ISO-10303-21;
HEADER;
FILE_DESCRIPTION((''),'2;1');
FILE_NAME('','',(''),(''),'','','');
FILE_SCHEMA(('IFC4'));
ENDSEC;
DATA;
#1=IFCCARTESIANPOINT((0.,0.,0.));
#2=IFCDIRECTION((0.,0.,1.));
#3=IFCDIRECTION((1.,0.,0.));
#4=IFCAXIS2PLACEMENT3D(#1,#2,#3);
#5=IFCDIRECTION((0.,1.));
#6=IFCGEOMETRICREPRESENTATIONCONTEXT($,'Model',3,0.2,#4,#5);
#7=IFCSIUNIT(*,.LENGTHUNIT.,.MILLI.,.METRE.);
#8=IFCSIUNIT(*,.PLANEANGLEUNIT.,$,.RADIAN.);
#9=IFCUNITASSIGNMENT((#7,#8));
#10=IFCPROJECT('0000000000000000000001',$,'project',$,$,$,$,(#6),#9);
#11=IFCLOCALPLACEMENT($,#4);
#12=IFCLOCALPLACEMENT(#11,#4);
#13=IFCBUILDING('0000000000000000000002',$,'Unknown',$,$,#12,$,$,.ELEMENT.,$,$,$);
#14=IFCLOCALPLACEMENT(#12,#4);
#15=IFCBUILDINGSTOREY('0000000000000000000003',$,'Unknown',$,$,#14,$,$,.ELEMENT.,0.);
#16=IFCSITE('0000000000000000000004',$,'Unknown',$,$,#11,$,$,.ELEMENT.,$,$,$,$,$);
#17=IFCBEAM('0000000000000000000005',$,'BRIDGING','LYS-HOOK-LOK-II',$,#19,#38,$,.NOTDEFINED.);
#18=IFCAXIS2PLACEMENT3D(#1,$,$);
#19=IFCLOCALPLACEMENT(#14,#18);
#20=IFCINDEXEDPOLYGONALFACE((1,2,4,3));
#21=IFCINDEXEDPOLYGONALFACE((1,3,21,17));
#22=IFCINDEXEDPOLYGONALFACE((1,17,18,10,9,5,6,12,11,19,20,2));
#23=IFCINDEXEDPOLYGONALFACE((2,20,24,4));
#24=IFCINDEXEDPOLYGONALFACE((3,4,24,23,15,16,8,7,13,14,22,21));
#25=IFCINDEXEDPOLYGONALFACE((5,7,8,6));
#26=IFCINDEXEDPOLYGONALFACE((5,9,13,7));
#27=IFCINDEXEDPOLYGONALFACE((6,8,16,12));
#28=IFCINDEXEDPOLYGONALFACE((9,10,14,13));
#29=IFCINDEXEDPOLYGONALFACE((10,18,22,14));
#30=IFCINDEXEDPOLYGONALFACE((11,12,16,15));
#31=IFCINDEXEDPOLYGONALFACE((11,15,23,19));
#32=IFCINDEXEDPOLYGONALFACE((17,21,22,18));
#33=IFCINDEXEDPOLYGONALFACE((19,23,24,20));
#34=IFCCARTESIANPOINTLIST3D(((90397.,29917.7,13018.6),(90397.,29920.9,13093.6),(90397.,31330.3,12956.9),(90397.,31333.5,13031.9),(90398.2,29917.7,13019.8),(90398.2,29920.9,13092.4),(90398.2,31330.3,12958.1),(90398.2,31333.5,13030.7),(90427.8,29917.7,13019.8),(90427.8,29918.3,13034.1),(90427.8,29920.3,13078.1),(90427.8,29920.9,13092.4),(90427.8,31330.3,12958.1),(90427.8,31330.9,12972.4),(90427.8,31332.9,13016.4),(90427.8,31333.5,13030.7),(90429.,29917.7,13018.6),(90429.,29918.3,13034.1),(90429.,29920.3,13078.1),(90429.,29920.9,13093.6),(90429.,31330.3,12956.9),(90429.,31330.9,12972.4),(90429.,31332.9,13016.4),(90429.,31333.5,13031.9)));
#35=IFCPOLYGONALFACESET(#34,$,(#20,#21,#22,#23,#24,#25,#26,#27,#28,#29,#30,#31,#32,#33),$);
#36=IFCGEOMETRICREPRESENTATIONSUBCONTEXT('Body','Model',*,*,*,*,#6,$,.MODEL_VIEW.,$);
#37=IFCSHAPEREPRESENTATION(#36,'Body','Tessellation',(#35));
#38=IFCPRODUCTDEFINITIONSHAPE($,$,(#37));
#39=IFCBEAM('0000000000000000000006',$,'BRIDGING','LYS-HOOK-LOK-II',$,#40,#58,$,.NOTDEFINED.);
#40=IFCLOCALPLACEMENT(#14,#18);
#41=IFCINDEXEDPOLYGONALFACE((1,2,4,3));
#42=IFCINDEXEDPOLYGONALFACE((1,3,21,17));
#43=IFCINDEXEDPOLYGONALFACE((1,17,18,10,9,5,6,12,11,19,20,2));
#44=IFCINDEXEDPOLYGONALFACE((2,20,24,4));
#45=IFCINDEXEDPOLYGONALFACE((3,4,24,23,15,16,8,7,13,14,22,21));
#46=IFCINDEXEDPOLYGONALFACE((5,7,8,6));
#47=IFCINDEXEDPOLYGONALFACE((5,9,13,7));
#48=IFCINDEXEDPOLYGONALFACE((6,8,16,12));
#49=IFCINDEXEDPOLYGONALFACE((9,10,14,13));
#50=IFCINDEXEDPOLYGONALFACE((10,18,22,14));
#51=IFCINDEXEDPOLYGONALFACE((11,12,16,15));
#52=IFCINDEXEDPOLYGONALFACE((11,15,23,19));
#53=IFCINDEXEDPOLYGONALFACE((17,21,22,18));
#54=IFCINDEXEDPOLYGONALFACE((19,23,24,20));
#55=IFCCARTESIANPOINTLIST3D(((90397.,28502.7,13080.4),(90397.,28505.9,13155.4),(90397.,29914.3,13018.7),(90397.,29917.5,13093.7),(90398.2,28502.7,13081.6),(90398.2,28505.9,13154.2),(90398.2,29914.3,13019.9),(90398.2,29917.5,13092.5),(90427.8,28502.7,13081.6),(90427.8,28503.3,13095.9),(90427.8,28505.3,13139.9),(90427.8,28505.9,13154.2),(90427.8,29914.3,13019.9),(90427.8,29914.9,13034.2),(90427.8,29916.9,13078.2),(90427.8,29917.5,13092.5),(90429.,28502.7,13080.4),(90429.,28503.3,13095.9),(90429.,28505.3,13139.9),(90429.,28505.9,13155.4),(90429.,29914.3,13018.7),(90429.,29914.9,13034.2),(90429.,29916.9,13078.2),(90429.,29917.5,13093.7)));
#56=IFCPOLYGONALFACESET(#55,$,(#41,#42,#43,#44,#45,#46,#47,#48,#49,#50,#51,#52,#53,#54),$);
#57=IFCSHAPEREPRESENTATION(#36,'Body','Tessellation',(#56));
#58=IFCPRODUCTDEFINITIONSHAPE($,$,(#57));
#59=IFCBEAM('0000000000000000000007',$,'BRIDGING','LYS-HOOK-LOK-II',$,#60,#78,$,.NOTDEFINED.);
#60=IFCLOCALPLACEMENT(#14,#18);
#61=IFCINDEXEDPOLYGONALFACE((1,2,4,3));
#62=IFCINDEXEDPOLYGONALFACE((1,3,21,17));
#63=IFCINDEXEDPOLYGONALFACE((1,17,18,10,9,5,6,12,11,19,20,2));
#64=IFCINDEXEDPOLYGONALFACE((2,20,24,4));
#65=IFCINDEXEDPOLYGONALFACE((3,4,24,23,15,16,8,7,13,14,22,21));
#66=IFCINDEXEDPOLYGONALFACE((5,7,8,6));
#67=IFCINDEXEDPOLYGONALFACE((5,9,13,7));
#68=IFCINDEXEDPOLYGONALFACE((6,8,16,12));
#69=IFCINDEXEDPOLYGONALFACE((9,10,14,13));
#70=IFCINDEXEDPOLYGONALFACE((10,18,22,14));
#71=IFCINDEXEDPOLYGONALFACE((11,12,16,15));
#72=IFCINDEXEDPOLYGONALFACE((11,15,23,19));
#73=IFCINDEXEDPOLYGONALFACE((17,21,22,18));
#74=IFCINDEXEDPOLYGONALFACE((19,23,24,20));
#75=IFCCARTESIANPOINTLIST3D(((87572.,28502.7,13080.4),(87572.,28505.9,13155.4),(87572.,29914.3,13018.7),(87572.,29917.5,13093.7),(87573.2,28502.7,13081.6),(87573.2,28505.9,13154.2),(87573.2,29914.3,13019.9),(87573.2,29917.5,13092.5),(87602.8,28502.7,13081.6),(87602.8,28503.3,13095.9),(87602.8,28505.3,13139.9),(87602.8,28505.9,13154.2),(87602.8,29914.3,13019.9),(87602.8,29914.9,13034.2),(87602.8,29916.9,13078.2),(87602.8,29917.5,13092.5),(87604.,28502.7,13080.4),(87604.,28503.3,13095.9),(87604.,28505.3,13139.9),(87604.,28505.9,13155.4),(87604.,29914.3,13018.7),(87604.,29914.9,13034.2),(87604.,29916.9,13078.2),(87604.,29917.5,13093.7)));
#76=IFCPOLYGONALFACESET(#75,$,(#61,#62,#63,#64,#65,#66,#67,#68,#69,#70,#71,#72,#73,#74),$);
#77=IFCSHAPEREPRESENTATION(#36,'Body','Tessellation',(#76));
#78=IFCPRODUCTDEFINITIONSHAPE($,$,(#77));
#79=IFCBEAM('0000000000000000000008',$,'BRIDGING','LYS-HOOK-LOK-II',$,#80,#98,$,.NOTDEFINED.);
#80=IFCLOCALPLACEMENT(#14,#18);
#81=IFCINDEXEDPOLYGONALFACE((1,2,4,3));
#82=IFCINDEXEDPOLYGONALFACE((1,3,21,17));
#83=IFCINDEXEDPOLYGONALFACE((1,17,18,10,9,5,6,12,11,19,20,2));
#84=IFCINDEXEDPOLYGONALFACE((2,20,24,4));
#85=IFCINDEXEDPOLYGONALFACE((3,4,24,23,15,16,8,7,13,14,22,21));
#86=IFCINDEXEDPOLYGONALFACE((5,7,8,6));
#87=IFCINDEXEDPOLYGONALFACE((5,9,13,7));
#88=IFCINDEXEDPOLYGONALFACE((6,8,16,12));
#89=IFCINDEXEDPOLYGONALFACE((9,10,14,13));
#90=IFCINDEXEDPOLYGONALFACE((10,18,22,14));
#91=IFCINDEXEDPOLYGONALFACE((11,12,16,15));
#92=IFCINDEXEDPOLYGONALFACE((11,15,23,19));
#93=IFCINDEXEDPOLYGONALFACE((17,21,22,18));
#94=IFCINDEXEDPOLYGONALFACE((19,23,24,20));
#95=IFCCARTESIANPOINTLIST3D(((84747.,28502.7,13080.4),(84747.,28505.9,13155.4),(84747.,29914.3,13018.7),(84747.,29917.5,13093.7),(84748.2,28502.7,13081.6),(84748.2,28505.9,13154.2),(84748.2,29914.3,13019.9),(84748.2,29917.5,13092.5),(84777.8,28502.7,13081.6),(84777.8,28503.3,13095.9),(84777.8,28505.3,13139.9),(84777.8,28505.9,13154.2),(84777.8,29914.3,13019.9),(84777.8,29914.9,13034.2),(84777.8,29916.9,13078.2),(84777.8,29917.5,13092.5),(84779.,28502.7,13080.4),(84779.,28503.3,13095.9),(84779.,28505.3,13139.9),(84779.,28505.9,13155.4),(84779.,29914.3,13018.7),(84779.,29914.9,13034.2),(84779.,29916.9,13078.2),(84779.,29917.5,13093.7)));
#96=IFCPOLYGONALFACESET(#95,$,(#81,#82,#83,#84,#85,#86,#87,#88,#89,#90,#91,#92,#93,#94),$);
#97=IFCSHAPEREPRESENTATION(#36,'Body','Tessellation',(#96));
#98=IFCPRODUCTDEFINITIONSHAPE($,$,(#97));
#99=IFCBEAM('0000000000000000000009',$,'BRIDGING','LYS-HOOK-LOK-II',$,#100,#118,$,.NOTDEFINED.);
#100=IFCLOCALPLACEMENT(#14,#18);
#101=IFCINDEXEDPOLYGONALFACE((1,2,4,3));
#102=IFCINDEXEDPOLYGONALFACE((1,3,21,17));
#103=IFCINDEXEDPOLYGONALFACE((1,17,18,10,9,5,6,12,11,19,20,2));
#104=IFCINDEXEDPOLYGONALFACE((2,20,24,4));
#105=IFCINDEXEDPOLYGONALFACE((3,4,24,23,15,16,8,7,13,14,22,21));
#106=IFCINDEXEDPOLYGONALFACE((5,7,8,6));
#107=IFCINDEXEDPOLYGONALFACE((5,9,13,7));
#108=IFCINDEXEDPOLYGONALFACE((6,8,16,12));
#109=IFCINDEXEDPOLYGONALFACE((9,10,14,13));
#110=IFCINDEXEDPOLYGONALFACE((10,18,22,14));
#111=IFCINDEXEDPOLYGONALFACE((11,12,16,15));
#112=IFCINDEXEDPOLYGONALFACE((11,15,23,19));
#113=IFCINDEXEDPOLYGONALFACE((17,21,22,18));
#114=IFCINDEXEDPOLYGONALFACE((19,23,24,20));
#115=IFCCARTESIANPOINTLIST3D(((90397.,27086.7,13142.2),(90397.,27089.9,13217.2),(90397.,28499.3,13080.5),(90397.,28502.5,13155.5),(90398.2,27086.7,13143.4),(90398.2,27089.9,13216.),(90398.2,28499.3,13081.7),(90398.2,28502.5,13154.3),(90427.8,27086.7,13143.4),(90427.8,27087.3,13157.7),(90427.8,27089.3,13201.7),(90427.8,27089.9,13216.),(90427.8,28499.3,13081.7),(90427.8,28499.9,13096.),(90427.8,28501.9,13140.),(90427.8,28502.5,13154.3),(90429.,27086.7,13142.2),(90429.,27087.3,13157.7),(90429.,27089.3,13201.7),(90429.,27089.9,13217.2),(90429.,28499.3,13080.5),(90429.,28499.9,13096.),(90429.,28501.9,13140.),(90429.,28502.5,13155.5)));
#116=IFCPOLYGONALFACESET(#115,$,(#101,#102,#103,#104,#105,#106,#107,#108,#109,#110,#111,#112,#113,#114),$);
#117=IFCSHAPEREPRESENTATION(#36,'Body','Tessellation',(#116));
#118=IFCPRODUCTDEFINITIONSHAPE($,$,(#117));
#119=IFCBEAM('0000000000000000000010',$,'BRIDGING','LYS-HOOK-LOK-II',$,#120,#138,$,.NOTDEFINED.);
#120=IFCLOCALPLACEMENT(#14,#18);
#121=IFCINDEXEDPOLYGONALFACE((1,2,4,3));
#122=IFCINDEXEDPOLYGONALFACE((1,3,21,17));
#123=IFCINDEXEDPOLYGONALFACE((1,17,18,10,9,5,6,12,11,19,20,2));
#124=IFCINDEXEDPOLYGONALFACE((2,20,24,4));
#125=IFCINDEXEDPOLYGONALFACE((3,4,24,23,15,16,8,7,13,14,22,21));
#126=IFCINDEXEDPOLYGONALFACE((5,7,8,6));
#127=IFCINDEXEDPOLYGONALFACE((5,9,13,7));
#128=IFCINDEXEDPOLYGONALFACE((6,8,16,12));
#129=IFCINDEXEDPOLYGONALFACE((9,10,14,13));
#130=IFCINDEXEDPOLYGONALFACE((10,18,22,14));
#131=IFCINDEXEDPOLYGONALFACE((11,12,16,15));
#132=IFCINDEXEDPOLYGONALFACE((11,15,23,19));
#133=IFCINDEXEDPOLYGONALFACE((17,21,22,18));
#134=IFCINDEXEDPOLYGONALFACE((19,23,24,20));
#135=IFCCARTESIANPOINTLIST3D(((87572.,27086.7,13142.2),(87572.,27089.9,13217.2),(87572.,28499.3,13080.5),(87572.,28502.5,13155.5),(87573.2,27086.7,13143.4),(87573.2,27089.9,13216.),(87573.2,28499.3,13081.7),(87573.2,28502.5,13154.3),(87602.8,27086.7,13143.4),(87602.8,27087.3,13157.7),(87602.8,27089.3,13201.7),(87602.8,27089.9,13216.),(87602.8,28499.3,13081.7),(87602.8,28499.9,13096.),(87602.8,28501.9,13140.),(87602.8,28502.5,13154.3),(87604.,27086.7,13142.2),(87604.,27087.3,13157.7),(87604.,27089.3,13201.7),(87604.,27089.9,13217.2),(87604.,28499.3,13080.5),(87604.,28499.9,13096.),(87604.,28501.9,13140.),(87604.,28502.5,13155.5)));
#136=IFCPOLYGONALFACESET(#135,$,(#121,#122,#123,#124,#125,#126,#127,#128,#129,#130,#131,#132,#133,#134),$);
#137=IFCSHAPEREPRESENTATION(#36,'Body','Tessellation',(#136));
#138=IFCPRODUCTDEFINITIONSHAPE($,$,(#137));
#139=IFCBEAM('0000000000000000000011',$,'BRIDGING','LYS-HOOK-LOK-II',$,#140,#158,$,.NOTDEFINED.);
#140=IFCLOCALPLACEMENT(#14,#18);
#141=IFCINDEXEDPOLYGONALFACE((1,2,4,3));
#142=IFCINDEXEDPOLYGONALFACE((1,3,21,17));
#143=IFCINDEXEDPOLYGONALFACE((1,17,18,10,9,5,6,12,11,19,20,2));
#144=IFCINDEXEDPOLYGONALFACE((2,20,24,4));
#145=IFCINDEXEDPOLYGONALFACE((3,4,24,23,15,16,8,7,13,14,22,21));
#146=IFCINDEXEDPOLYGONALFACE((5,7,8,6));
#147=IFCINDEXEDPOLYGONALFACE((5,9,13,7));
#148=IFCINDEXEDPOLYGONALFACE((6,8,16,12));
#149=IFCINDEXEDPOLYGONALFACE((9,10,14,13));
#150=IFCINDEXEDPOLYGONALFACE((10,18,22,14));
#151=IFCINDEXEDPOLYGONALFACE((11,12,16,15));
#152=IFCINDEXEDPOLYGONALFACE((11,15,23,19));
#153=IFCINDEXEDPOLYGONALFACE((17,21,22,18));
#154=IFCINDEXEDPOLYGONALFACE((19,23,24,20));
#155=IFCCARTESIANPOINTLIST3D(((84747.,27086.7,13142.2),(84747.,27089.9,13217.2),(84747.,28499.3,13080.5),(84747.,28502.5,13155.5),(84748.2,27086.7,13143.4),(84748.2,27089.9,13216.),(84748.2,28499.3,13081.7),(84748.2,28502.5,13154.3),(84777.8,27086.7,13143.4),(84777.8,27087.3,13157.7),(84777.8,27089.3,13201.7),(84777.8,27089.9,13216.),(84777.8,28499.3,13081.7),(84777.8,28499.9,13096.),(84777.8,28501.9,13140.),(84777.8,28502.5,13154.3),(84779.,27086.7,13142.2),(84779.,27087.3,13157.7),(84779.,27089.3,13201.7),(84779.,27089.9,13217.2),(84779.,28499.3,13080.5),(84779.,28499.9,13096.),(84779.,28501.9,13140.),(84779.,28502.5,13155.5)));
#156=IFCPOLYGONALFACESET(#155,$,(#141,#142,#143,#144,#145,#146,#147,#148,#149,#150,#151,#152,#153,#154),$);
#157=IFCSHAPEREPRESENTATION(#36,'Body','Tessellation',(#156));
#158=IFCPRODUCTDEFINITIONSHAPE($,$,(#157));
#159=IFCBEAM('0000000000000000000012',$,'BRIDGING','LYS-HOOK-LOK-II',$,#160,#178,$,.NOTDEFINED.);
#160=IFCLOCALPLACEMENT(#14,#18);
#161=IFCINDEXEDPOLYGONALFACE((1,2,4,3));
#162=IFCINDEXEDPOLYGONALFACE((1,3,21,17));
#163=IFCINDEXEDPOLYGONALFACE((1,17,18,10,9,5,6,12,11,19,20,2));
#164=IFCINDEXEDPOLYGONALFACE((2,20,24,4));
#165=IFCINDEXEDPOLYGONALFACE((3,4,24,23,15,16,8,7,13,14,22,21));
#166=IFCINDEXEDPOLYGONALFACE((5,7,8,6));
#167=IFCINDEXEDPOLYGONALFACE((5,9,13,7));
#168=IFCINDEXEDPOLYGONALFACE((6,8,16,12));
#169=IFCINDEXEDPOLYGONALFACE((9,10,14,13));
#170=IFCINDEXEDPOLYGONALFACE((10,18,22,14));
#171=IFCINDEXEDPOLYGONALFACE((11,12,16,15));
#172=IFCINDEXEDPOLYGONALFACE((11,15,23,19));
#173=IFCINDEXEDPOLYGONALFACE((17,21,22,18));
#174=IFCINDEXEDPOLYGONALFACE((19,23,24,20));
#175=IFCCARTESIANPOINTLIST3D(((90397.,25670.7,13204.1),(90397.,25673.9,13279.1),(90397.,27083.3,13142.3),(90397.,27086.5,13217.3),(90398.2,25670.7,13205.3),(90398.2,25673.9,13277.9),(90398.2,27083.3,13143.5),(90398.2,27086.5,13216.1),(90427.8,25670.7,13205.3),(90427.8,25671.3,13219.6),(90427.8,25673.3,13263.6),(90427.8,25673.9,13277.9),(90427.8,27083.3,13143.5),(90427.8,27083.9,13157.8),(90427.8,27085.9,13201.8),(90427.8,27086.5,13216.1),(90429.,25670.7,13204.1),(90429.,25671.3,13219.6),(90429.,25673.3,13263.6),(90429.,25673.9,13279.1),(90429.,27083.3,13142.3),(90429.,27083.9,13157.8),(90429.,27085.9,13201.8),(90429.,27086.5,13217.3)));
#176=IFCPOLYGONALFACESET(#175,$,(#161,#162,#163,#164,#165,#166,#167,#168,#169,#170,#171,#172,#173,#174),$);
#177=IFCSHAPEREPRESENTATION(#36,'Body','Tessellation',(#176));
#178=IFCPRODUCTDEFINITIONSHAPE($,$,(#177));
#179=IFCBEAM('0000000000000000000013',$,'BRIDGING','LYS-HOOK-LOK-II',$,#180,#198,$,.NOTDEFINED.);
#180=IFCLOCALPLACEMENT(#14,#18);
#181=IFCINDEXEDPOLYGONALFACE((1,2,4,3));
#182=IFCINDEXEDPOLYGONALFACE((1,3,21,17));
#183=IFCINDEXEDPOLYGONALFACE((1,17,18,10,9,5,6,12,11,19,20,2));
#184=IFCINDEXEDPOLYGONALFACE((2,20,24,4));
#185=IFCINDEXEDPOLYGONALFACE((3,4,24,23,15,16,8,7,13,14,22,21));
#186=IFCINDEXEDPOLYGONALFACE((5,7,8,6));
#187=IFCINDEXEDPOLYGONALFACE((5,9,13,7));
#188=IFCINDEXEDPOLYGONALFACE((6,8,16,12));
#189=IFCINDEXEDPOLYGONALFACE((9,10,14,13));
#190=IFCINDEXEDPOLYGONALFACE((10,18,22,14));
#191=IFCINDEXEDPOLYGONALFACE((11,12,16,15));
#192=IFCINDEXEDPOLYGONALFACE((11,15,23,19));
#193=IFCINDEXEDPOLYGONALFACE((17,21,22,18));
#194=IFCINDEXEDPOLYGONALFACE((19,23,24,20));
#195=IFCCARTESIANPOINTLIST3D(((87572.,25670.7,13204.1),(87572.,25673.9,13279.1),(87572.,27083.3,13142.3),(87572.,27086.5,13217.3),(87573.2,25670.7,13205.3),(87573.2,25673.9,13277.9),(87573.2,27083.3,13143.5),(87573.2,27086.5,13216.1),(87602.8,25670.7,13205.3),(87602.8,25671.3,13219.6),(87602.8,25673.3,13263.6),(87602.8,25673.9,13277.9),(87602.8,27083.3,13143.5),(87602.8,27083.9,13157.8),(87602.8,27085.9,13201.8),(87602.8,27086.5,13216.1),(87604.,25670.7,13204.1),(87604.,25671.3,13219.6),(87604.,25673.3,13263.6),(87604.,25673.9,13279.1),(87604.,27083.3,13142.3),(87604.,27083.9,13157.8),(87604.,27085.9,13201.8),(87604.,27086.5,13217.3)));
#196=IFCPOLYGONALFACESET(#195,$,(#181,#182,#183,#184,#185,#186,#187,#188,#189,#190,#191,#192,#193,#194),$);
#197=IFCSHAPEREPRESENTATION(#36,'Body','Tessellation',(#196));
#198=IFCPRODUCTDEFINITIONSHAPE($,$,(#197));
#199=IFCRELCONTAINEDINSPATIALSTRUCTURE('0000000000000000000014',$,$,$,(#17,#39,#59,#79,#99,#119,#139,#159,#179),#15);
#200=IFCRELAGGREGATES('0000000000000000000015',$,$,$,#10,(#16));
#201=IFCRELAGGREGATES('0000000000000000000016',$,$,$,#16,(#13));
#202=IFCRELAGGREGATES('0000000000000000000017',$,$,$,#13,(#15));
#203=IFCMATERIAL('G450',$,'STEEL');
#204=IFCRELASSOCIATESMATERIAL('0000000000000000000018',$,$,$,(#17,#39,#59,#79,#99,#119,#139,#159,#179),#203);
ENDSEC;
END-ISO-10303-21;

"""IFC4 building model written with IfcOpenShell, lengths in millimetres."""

from ifc_helpers import new_model, si_unit, direction, frame, origin_with_axes, place, context, subcontext, project, spatial, line, indexed_curve, outline, extrude, material, element, save


model = new_model("IFC4")

# Units and contexts
model_context = context("Model", 3, precision=0.2, world=origin_with_axes(), true_north=direction((0.0, 1.0)))
body_context = subcontext(model_context, "Body", "Model", "MODEL_VIEW")
ifc_project = project(units=[si_unit("LENGTHUNIT", "METRE", prefix="MILLI"), si_unit("PLANEANGLEUNIT", "RADIAN")], contexts=[model_context])

# Site, building, storey
site_placement = place(None, origin_with_axes())
site = spatial("IfcSite", under=ifc_project, at=site_placement, Name="Unknown", CompositionType="ELEMENT")
building_placement = place(site_placement, origin_with_axes())
building = spatial("IfcBuilding", under=site, at=building_placement, Name="Unknown", CompositionType="ELEMENT")
storey_placement = place(building_placement, origin_with_axes())
storey = spatial("IfcBuildingStorey", under=building, at=storey_placement, Name="Unknown", CompositionType="ELEMENT", Elevation=0.0)

# Beams
ifc_material_1 = material(Name="G450", Category="STEEL")
beam_placement = place(storey_placement, frame((90413.0, 29919.3, 13056.1), z_axis=(1.0, 0.0, 0.0), x_axis=(0.0, 0.999047, -0.043637)))
element("IfcBeam", 1, at=beam_placement, inside=storey, material=ifc_material_1, Name="BRIDGING", Description="LYS-HOOK-LOK-II", PredefinedType="NOTDEFINED", context=body_context, shape_type="SolidModel", body=[
    extrude(outline(indexed_curve([(16.0, -37.5), (16.0, -22.0), (14.8, -22.0), (14.8, -36.3), (-14.8, -36.3), (-14.8, 36.3), (14.8, 36.3), (14.8, 22.0), (16.0, 22.0), (16.0, 37.5), (-16.0, 37.5), (-16.0, -37.5)], segments=[line(1, 2, 3, 4, 5, 6, 7, 8, 9, 10, 11, 12, 1)])), frame((0.0, 0.0, 0.0), z_axis=(-1.0, 0.0, 0.0), x_axis=(0.0, 0.0, 1.0)), (0.0, 0.0, -1.0), 1413.9),
])
for number, where, z_axis, x_axis, name in (
    (2, (90413.0, 28504.3, 13117.9), (1.0, 0.0, 0.0), (0.0, 0.999046, -0.043668), "BRIDGING"),
    (3, (87588.0, 28504.3, 13117.9), (1.0, 0.0, 0.0), (0.0, 0.999046, -0.043668), "BRIDGING"),
    (4, (84763.0, 28504.3, 13117.9), (1.0, 0.0, 0.0), (0.0, 0.999046, -0.043668), "BRIDGING"),
):
    element("IfcBeam", number, at=place(storey_placement, frame(where, z_axis=z_axis, x_axis=x_axis)), inside=storey, material=ifc_material_1, Name=name, Description="LYS-HOOK-LOK-II", PredefinedType="NOTDEFINED", context=body_context, shape_type="SolidModel", body=[
        extrude(outline(indexed_curve([(16.0, -37.5), (16.0, -22.0), (14.8, -22.0), (14.8, -36.3), (-14.8, -36.3), (-14.8, 36.3), (14.8, 36.3), (14.8, 22.0), (16.0, 22.0), (16.0, 37.5), (-16.0, 37.5), (-16.0, -37.5)], segments=[line(1, 2, 3, 4, 5, 6, 7, 8, 9, 10, 11, 12, 1)])), frame((0.0, 0.0, 0.0), z_axis=(-1.0, 0.0, 0.0), x_axis=(0.0, 0.0, 1.0)), (0.0, 0.0, -1.0), 1412.9),
    ])
for number, where, z_axis, x_axis, name in (
    (5, (90413.0, 27088.3, 13179.7), (1.0, 0.0, 0.0), (0.0, 0.999047, -0.043637), "BRIDGING"),
    (6, (87588.0, 27088.3, 13179.7), (1.0, 0.0, 0.0), (0.0, 0.999047, -0.043637), "BRIDGING"),
    (7, (84763.0, 27088.3, 13179.7), (1.0, 0.0, 0.0), (0.0, 0.999047, -0.043637), "BRIDGING"),
):
    element("IfcBeam", number, at=place(storey_placement, frame(where, z_axis=z_axis, x_axis=x_axis)), inside=storey, material=ifc_material_1, Name=name, Description="LYS-HOOK-LOK-II", PredefinedType="NOTDEFINED", context=body_context, shape_type="SolidModel", body=[
        extrude(outline(indexed_curve([(16.0, -37.5), (16.0, -22.0), (14.8, -22.0), (14.8, -36.3), (-14.8, -36.3), (-14.8, 36.3), (14.8, 36.3), (14.8, 22.0), (16.0, 22.0), (16.0, 37.5), (-16.0, 37.5), (-16.0, -37.5)], segments=[line(1, 2, 3, 4, 5, 6, 7, 8, 9, 10, 11, 12, 1)])), frame((0.0, 0.0, 0.0), z_axis=(-1.0, 0.0, 0.0), x_axis=(0.0, 0.0, 1.0)), (0.0, 0.0, -1.0), 1413.9),
    ])
for number, where, z_axis, x_axis, name in (
    (8, (90413.0, 25672.3, 13241.6), (1.0, 0.0, 0.0), (0.0, 0.999044, -0.043707), "BRIDGING"),
    (9, (87588.0, 25672.3, 13241.6), (1.0, 0.0, 0.0), (0.0, 0.999044, -0.043707), "BRIDGING"),
):
    element("IfcBeam", number, at=place(storey_placement, frame(where, z_axis=z_axis, x_axis=x_axis)), inside=storey, material=ifc_material_1, Name=name, Description="LYS-HOOK-LOK-II", PredefinedType="NOTDEFINED", context=body_context, shape_type="SolidModel", body=[
        extrude(outline(indexed_curve([(16.0, -37.5), (16.0, -22.0), (14.8, -22.0), (14.8, -36.3), (-14.8, -36.3), (-14.8, 36.3), (14.8, 36.3), (14.8, 22.0), (16.0, 22.0), (16.0, 37.5), (-16.0, 37.5), (-16.0, -37.5)], segments=[line(1, 2, 3, 4, 5, 6, 7, 8, 9, 10, 11, 12, 1)])), frame((0.0, 0.0, 0.0), z_axis=(-1.0, 0.0, 0.0), x_axis=(0.0, 0.0, 1.0)), (0.0, 0.0, -1.0), 1414.0),
    ])

save(model, "model.ifc")
